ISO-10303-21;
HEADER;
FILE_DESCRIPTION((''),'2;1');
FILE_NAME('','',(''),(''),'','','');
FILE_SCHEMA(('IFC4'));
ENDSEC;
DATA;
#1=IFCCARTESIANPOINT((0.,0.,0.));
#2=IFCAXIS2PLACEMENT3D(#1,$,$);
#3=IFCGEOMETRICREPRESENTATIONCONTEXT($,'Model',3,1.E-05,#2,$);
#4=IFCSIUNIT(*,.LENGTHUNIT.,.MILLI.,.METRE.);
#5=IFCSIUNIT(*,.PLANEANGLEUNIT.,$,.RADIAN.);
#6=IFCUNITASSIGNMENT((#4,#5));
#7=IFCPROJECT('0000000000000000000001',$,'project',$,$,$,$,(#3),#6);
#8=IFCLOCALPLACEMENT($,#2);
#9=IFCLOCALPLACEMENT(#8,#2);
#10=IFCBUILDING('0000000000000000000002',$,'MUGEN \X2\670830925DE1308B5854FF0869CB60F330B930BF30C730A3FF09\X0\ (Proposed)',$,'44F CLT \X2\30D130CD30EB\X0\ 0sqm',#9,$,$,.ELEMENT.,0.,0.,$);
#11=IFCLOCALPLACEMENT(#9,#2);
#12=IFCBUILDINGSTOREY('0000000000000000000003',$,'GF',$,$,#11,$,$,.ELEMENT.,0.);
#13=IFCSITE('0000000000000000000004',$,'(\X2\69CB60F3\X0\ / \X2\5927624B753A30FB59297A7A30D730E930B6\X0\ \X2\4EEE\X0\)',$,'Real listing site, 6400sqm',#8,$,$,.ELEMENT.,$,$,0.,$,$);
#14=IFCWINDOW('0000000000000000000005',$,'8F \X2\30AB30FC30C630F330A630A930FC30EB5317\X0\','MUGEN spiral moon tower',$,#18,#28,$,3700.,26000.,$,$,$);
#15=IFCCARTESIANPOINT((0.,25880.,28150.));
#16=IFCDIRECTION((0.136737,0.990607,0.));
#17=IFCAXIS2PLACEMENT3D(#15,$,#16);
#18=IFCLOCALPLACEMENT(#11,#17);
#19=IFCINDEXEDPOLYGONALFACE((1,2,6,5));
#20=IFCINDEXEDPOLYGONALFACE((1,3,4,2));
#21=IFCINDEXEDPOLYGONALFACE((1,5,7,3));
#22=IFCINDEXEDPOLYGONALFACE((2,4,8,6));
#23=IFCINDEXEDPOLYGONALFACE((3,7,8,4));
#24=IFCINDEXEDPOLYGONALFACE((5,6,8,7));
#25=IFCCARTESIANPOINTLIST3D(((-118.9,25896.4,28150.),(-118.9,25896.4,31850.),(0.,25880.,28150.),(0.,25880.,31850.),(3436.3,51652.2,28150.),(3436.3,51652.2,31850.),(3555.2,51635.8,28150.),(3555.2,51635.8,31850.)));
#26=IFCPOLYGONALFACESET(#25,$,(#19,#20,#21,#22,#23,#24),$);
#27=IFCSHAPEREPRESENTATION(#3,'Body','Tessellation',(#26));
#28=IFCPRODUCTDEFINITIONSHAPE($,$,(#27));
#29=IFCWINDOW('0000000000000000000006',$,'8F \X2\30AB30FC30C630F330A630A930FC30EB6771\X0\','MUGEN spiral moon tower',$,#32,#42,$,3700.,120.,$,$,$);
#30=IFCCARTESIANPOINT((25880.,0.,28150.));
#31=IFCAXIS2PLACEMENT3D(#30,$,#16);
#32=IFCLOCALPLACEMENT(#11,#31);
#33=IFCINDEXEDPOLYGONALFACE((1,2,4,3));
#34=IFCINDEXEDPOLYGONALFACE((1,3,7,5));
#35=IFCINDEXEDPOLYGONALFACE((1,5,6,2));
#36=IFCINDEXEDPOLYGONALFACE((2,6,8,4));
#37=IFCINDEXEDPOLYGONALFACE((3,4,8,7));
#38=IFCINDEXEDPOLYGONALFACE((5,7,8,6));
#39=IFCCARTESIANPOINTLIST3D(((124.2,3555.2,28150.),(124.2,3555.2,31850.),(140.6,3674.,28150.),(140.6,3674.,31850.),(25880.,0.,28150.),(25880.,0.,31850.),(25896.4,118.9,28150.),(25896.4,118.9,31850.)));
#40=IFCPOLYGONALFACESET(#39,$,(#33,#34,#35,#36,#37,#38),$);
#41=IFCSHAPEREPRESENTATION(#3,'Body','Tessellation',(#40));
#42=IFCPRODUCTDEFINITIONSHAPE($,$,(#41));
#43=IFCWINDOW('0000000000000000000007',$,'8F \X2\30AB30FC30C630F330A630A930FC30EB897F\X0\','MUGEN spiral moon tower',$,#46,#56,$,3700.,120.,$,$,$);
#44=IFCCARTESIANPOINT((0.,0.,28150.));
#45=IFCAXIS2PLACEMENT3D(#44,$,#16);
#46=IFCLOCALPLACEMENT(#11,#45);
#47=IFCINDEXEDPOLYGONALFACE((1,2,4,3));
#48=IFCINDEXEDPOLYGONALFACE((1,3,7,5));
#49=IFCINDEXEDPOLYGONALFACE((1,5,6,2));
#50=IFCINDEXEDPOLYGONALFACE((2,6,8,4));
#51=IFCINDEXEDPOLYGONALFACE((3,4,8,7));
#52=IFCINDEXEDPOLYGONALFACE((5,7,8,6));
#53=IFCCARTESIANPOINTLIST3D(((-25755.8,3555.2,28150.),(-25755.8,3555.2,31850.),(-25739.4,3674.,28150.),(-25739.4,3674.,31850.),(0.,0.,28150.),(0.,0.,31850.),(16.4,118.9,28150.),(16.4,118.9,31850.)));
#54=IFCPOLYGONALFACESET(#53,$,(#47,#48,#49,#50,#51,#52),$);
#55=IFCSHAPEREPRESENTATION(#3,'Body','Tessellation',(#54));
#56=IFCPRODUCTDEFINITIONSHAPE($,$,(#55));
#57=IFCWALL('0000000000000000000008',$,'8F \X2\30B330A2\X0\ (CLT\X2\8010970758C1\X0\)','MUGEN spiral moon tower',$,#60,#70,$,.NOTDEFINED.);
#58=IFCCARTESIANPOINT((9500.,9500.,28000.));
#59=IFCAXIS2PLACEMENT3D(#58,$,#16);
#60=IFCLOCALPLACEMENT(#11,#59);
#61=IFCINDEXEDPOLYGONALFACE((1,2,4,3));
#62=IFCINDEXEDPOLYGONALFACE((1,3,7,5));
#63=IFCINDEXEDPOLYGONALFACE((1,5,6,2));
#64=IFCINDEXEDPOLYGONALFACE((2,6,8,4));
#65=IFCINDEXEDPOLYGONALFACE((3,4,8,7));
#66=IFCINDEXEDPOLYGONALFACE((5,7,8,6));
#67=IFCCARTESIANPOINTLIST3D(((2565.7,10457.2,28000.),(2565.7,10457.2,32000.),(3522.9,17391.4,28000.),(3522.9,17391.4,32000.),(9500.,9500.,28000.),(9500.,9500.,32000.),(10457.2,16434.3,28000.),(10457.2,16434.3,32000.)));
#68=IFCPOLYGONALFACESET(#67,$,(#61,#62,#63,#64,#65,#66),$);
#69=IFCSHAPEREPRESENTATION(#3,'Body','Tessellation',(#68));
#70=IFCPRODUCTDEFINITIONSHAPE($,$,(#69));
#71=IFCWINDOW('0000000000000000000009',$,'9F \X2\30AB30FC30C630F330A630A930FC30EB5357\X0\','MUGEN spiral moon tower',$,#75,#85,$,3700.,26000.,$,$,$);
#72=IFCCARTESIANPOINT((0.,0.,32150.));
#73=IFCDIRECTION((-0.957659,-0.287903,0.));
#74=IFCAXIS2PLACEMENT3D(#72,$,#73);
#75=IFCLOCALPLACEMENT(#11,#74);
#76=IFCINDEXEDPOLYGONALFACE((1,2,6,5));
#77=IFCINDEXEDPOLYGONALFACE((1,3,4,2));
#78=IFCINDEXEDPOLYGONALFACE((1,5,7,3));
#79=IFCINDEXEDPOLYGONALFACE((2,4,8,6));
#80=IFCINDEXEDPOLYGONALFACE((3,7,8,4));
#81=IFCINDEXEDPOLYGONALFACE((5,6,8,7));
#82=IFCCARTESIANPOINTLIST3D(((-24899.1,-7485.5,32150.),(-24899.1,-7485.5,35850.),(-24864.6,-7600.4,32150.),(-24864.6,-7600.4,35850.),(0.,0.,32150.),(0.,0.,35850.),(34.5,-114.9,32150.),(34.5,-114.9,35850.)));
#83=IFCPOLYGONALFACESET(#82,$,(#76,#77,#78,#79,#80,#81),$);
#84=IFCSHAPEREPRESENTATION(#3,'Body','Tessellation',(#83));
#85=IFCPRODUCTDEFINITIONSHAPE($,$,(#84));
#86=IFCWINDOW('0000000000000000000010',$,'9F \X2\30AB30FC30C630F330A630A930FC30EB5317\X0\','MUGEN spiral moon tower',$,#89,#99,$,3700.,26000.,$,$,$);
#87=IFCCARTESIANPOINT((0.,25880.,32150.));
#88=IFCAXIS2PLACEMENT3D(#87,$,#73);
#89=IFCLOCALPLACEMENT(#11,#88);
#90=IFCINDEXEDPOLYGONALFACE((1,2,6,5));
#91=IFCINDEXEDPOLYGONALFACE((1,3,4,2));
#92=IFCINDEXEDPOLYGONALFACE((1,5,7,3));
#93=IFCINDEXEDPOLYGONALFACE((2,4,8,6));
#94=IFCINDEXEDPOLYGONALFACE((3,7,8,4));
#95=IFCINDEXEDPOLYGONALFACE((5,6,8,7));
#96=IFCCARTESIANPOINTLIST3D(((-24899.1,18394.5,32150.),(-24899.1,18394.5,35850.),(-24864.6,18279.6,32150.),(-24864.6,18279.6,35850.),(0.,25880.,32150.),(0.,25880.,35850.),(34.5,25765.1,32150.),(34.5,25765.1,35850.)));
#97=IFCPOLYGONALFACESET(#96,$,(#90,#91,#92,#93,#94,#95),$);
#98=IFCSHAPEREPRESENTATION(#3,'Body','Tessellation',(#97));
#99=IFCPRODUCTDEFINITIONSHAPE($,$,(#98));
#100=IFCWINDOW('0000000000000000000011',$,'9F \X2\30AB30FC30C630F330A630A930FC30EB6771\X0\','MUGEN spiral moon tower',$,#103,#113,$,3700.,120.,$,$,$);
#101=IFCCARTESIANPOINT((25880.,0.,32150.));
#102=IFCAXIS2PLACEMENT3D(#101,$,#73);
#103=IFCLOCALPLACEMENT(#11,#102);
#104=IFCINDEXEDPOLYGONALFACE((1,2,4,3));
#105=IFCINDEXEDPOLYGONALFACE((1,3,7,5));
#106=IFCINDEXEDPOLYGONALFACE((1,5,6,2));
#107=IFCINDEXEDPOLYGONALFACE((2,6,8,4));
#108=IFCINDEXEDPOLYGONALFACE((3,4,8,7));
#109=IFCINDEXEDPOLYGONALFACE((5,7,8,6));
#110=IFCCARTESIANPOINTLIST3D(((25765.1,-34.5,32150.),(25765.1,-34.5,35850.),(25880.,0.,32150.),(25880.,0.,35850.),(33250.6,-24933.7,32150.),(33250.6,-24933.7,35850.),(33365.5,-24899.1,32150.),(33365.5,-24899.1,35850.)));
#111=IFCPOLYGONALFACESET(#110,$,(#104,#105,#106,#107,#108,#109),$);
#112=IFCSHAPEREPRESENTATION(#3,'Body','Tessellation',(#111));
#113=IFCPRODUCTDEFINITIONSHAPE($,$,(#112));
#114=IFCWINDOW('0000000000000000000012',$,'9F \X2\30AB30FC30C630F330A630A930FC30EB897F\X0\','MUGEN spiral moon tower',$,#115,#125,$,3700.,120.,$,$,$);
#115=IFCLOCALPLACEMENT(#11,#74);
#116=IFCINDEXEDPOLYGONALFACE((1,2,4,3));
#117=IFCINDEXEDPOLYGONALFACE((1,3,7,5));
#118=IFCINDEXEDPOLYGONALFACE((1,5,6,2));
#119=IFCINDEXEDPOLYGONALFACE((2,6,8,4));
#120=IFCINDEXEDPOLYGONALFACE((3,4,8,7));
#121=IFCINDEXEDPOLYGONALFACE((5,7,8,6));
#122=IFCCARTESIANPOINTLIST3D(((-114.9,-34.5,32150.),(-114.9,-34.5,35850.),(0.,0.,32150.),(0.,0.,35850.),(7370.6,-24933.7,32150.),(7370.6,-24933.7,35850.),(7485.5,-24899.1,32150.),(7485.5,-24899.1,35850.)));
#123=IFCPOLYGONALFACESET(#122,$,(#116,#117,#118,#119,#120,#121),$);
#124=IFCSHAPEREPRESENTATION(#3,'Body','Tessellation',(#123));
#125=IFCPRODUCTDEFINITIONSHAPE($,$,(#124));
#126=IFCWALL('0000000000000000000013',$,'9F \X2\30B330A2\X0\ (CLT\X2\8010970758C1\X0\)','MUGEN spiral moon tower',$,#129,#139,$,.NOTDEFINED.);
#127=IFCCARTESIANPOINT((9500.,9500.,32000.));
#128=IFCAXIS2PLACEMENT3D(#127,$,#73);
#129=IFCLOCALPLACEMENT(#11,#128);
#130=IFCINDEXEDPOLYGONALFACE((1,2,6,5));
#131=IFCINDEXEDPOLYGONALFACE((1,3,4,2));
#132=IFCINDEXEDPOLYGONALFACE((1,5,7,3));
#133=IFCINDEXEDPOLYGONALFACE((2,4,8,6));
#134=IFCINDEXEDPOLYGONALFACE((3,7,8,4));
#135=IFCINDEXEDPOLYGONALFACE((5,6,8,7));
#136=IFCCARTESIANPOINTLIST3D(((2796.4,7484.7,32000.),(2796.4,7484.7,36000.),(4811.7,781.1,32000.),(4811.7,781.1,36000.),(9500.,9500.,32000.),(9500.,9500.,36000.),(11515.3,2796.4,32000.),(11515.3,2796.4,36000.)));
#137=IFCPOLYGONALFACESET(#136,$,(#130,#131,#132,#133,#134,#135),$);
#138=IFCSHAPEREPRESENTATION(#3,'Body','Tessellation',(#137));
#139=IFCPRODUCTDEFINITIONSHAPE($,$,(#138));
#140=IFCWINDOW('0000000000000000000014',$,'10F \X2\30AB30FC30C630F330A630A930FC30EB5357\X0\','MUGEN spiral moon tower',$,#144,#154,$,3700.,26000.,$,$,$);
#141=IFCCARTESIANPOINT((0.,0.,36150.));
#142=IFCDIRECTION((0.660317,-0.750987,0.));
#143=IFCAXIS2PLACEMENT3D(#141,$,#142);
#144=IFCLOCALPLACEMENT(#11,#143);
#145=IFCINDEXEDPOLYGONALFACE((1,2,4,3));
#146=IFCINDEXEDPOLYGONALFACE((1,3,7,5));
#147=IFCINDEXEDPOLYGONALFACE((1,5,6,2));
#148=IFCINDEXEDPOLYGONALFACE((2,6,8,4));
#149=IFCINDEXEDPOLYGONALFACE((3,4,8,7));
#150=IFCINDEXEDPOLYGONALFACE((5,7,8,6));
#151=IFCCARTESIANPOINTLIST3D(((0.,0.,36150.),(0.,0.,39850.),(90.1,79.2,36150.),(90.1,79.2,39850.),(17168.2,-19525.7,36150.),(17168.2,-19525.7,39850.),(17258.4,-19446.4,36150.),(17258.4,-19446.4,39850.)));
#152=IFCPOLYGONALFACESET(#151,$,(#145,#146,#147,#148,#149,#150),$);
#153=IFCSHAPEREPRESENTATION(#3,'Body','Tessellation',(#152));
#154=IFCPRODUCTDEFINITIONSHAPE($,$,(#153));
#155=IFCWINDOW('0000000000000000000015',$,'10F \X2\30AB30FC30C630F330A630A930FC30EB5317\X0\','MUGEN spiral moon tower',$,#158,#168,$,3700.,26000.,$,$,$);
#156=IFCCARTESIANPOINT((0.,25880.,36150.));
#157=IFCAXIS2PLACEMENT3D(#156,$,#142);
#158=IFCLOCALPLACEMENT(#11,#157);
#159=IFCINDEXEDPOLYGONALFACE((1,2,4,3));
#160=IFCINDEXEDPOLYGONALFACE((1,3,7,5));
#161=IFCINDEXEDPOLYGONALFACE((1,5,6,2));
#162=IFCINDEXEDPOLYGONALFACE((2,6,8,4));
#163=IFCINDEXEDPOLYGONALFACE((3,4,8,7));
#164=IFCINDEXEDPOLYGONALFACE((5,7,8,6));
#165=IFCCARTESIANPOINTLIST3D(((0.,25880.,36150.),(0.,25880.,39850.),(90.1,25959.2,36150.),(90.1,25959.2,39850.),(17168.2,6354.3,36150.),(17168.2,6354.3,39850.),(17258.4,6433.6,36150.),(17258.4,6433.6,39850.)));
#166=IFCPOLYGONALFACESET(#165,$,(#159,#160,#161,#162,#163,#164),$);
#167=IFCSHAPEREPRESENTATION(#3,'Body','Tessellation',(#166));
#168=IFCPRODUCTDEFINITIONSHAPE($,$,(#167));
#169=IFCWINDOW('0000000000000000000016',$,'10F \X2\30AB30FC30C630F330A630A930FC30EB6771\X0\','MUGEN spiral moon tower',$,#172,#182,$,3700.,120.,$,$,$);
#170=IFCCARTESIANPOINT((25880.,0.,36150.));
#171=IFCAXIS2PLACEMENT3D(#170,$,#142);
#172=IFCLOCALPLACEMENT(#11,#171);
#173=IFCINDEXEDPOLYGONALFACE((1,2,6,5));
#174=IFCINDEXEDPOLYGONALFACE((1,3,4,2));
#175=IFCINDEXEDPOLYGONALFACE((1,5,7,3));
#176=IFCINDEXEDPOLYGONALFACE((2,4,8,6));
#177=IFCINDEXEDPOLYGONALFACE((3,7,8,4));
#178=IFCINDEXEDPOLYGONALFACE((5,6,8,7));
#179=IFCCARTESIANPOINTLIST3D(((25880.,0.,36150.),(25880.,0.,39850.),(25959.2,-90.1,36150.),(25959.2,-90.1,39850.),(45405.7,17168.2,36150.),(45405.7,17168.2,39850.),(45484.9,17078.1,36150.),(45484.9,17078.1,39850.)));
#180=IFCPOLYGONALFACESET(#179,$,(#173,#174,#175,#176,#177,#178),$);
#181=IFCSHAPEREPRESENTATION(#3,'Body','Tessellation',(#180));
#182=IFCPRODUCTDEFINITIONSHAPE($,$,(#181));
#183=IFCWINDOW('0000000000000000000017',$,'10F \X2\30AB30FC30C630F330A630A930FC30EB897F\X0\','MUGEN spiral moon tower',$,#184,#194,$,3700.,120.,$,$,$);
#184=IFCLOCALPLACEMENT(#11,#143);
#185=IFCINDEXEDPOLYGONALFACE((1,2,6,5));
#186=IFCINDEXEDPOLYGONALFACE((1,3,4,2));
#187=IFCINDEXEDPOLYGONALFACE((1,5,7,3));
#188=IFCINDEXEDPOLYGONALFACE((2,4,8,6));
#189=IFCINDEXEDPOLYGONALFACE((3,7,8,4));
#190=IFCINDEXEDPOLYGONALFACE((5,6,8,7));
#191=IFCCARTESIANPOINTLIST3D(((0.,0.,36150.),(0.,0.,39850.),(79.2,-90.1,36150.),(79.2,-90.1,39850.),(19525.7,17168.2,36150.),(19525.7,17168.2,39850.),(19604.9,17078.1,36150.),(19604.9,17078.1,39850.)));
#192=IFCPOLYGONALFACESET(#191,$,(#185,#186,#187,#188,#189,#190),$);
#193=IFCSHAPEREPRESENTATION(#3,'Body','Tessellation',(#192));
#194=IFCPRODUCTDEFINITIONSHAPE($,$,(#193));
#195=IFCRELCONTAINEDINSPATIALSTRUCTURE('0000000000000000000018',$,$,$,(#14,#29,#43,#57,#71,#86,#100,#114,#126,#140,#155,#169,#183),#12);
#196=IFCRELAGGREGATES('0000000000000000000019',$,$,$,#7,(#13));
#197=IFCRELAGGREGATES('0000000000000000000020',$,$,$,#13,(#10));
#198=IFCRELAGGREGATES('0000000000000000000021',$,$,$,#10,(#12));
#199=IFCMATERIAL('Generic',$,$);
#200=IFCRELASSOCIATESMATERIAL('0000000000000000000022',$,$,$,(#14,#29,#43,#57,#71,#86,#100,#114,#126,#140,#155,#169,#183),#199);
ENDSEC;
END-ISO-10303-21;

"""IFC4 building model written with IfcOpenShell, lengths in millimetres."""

from ifc_helpers import new_model, si_unit, frame, frame_2d, origin, place, context, project, spatial, rectangle, extrude, material, element, save


model = new_model("IFC4")

# Units and contexts
model_context = context("Model", 3, precision=1e-05, world=origin())
ifc_project = project(units=[si_unit("LENGTHUNIT", "METRE", prefix="MILLI"), si_unit("PLANEANGLEUNIT", "RADIAN")], contexts=[model_context])

# Site, building, storey
site_placement = place(None, origin())
site = spatial("IfcSite", under=ifc_project, at=site_placement, Name="(構想 / 大手町・天空プラザ 仮)", ObjectType="Real listing site, 6400sqm", CompositionType="ELEMENT", RefElevation=0.0)
building_placement = place(site_placement, origin())
building = spatial("IfcBuilding", under=site, at=building_placement, Name="MUGEN 月を巡る塔（構想スタディ） (Proposed)", ObjectType="44F CLT パネル 0sqm", CompositionType="ELEMENT", ElevationOfRefHeight=0.0, ElevationOfTerrain=0.0)
storey_placement = place(building_placement, origin())
storey = spatial("IfcBuildingStorey", under=building, at=storey_placement, Name="GF", CompositionType="ELEMENT", Elevation=0.0)

# Shared definitions
ifc_material = material(Name="Generic")

# Windows
window_1_placement = place(storey_placement, frame((0.0, 25880.0, 28150.0), x_axis=(0.136737, 0.990607, 0.0)))
element("IfcWindow", 1, at=window_1_placement, inside=storey, material=ifc_material, Name="8F カーテンウォール北", Description="MUGEN spiral moon tower", OverallHeight=3700.0, OverallWidth=26000.0, context=model_context, shape_type="SweptSolid", body=[
    extrude(rectangle(XDim=26000.0, YDim=120.0, at=frame_2d((13000.0, 60.0))), frame((0.0, 25880.0, 28150.0), x_axis=(0.136737, 0.990607, 0.0)), (0.0, 0.0, 1.0), 3700.0),
])
window_2_placement = place(storey_placement, frame((25880.0, 0.0, 28150.0), x_axis=(0.136737, 0.990607, 0.0)))
element("IfcWindow", 2, at=window_2_placement, inside=storey, material=ifc_material, Name="8F カーテンウォール東", Description="MUGEN spiral moon tower", OverallHeight=3700.0, OverallWidth=120.0, context=model_context, shape_type="SweptSolid", body=[
    extrude(rectangle(XDim=120.0, YDim=26000.0, at=frame_2d((60.0, 13000.0))), frame((25880.0, 0.0, 28150.0), x_axis=(0.136737, 0.990607, 0.0)), (0.0, 0.0, 1.0), 3700.0),
])
window_3_placement = place(storey_placement, frame((0.0, 0.0, 28150.0), x_axis=(0.136737, 0.990607, 0.0)))
element("IfcWindow", 3, at=window_3_placement, inside=storey, material=ifc_material, Name="8F カーテンウォール西", Description="MUGEN spiral moon tower", OverallHeight=3700.0, OverallWidth=120.0, context=model_context, shape_type="SweptSolid", body=[
    extrude(rectangle(XDim=120.0, YDim=26000.0, at=frame_2d((60.0, 13000.0))), frame((0.0, 0.0, 28150.0), x_axis=(0.136737, 0.990607, 0.0)), (0.0, 0.0, 1.0), 3700.0),
])

# Wall
wall_1_placement = place(storey_placement, frame((9500.0, 9500.0, 28000.0), x_axis=(0.136737, 0.990607, 0.0)))
element("IfcWall", 4, at=wall_1_placement, inside=storey, material=ifc_material, Name="8F コア (CLT耐震壁)", Description="MUGEN spiral moon tower", PredefinedType="NOTDEFINED", context=model_context, shape_type="SweptSolid", body=[
    extrude(rectangle(XDim=7000.0, YDim=7000.0, at=frame_2d((3500.0, 3500.0))), frame((9500.0, 9500.0, 28000.0), x_axis=(0.136737, 0.990607, 0.0)), (0.0, 0.0, 1.0), 4000.0),
])

# Windows
window_4_placement = place(storey_placement, frame((0.0, 0.0, 32150.0), x_axis=(-0.957659, -0.287903, 0.0)))
element("IfcWindow", 5, at=window_4_placement, inside=storey, material=ifc_material, Name="9F カーテンウォール南", Description="MUGEN spiral moon tower", OverallHeight=3700.0, OverallWidth=26000.0, context=model_context, shape_type="SweptSolid", body=[
    extrude(rectangle(XDim=26000.0, YDim=120.0, at=frame_2d((13000.0, 60.0))), frame((0.0, 0.0, 32150.0), x_axis=(-0.957659, -0.287903, 0.0)), (0.0, 0.0, 1.0), 3700.0),
])
window_5_placement = place(storey_placement, frame((0.0, 25880.0, 32150.0), x_axis=(-0.957659, -0.287903, 0.0)))
element("IfcWindow", 6, at=window_5_placement, inside=storey, material=ifc_material, Name="9F カーテンウォール北", Description="MUGEN spiral moon tower", OverallHeight=3700.0, OverallWidth=26000.0, context=model_context, shape_type="SweptSolid", body=[
    extrude(rectangle(XDim=26000.0, YDim=120.0, at=frame_2d((13000.0, 60.0))), frame((0.0, 25880.0, 32150.0), x_axis=(-0.957659, -0.287903, 0.0)), (0.0, 0.0, 1.0), 3700.0),
])
window_6_placement = place(storey_placement, frame((25880.0, 0.0, 32150.0), x_axis=(-0.957659, -0.287903, 0.0)))
element("IfcWindow", 7, at=window_6_placement, inside=storey, material=ifc_material, Name="9F カーテンウォール東", Description="MUGEN spiral moon tower", OverallHeight=3700.0, OverallWidth=120.0, context=model_context, shape_type="SweptSolid", body=[
    extrude(rectangle(XDim=120.0, YDim=26000.0, at=frame_2d((60.0, 13000.0))), frame((25880.0, 0.0, 32150.0), x_axis=(-0.957659, -0.287903, 0.0)), (0.0, 0.0, 1.0), 3700.0),
])
window_7_placement = place(storey_placement, frame((0.0, 0.0, 32150.0), x_axis=(-0.957659, -0.287903, 0.0)))
element("IfcWindow", 8, at=window_7_placement, inside=storey, material=ifc_material, Name="9F カーテンウォール西", Description="MUGEN spiral moon tower", OverallHeight=3700.0, OverallWidth=120.0, context=model_context, shape_type="SweptSolid", body=[
    extrude(rectangle(XDim=120.0, YDim=26000.0, at=frame_2d((60.0, 13000.0))), frame((0.0, 0.0, 32150.0), x_axis=(-0.957659, -0.287903, 0.0)), (0.0, 0.0, 1.0), 3700.0),
])

# Wall
wall_2_placement = place(storey_placement, frame((9500.0, 9500.0, 32000.0), x_axis=(-0.957659, -0.287903, 0.0)))
element("IfcWall", 9, at=wall_2_placement, inside=storey, material=ifc_material, Name="9F コア (CLT耐震壁)", Description="MUGEN spiral moon tower", PredefinedType="NOTDEFINED", context=model_context, shape_type="SweptSolid", body=[
    extrude(rectangle(XDim=7000.0, YDim=7000.0, at=frame_2d((3500.0, 3500.0))), frame((9500.0, 9500.0, 32000.0), x_axis=(-0.957659, -0.287903, 0.0)), (0.0, 0.0, 1.0), 4000.0),
])

# Windows
window_8_placement = place(storey_placement, frame((0.0, 0.0, 36150.0), x_axis=(0.660317, -0.750987, 0.0)))
element("IfcWindow", 10, at=window_8_placement, inside=storey, material=ifc_material, Name="10F カーテンウォール南", Description="MUGEN spiral moon tower", OverallHeight=3700.0, OverallWidth=26000.0, context=model_context, shape_type="SweptSolid", body=[
    extrude(rectangle(XDim=26000.0, YDim=120.0, at=frame_2d((13000.0, 60.0))), frame((0.0, 0.0, 36150.0), x_axis=(0.660317, -0.750987, 0.0)), (0.0, 0.0, 1.0), 3700.0),
])
window_9_placement = place(storey_placement, frame((0.0, 25880.0, 36150.0), x_axis=(0.660317, -0.750987, 0.0)))
element("IfcWindow", 11, at=window_9_placement, inside=storey, material=ifc_material, Name="10F カーテンウォール北", Description="MUGEN spiral moon tower", OverallHeight=3700.0, OverallWidth=26000.0, context=model_context, shape_type="SweptSolid", body=[
    extrude(rectangle(XDim=26000.0, YDim=120.0, at=frame_2d((13000.0, 60.0))), frame((0.0, 25880.0, 36150.0), x_axis=(0.660317, -0.750987, 0.0)), (0.0, 0.0, 1.0), 3700.0),
])
window_10_placement = place(storey_placement, frame((25880.0, 0.0, 36150.0), x_axis=(0.660317, -0.750987, 0.0)))
element("IfcWindow", 12, at=window_10_placement, inside=storey, material=ifc_material, Name="10F カーテンウォール東", Description="MUGEN spiral moon tower", OverallHeight=3700.0, OverallWidth=120.0, context=model_context, shape_type="SweptSolid", body=[
    extrude(rectangle(XDim=120.0, YDim=26000.0, at=frame_2d((60.0, 13000.0))), frame((25880.0, 0.0, 36150.0), x_axis=(0.660317, -0.750987, 0.0)), (0.0, 0.0, 1.0), 3700.0),
])
window_11_placement = place(storey_placement, frame((0.0, 0.0, 36150.0), x_axis=(0.660317, -0.750987, 0.0)))
element("IfcWindow", 13, at=window_11_placement, inside=storey, material=ifc_material, Name="10F カーテンウォール西", Description="MUGEN spiral moon tower", OverallHeight=3700.0, OverallWidth=120.0, context=model_context, shape_type="SweptSolid", body=[
    extrude(rectangle(XDim=120.0, YDim=26000.0, at=frame_2d((60.0, 13000.0))), frame((0.0, 0.0, 36150.0), x_axis=(0.660317, -0.750987, 0.0)), (0.0, 0.0, 1.0), 3700.0),
])

save(model, "model.ifc")
